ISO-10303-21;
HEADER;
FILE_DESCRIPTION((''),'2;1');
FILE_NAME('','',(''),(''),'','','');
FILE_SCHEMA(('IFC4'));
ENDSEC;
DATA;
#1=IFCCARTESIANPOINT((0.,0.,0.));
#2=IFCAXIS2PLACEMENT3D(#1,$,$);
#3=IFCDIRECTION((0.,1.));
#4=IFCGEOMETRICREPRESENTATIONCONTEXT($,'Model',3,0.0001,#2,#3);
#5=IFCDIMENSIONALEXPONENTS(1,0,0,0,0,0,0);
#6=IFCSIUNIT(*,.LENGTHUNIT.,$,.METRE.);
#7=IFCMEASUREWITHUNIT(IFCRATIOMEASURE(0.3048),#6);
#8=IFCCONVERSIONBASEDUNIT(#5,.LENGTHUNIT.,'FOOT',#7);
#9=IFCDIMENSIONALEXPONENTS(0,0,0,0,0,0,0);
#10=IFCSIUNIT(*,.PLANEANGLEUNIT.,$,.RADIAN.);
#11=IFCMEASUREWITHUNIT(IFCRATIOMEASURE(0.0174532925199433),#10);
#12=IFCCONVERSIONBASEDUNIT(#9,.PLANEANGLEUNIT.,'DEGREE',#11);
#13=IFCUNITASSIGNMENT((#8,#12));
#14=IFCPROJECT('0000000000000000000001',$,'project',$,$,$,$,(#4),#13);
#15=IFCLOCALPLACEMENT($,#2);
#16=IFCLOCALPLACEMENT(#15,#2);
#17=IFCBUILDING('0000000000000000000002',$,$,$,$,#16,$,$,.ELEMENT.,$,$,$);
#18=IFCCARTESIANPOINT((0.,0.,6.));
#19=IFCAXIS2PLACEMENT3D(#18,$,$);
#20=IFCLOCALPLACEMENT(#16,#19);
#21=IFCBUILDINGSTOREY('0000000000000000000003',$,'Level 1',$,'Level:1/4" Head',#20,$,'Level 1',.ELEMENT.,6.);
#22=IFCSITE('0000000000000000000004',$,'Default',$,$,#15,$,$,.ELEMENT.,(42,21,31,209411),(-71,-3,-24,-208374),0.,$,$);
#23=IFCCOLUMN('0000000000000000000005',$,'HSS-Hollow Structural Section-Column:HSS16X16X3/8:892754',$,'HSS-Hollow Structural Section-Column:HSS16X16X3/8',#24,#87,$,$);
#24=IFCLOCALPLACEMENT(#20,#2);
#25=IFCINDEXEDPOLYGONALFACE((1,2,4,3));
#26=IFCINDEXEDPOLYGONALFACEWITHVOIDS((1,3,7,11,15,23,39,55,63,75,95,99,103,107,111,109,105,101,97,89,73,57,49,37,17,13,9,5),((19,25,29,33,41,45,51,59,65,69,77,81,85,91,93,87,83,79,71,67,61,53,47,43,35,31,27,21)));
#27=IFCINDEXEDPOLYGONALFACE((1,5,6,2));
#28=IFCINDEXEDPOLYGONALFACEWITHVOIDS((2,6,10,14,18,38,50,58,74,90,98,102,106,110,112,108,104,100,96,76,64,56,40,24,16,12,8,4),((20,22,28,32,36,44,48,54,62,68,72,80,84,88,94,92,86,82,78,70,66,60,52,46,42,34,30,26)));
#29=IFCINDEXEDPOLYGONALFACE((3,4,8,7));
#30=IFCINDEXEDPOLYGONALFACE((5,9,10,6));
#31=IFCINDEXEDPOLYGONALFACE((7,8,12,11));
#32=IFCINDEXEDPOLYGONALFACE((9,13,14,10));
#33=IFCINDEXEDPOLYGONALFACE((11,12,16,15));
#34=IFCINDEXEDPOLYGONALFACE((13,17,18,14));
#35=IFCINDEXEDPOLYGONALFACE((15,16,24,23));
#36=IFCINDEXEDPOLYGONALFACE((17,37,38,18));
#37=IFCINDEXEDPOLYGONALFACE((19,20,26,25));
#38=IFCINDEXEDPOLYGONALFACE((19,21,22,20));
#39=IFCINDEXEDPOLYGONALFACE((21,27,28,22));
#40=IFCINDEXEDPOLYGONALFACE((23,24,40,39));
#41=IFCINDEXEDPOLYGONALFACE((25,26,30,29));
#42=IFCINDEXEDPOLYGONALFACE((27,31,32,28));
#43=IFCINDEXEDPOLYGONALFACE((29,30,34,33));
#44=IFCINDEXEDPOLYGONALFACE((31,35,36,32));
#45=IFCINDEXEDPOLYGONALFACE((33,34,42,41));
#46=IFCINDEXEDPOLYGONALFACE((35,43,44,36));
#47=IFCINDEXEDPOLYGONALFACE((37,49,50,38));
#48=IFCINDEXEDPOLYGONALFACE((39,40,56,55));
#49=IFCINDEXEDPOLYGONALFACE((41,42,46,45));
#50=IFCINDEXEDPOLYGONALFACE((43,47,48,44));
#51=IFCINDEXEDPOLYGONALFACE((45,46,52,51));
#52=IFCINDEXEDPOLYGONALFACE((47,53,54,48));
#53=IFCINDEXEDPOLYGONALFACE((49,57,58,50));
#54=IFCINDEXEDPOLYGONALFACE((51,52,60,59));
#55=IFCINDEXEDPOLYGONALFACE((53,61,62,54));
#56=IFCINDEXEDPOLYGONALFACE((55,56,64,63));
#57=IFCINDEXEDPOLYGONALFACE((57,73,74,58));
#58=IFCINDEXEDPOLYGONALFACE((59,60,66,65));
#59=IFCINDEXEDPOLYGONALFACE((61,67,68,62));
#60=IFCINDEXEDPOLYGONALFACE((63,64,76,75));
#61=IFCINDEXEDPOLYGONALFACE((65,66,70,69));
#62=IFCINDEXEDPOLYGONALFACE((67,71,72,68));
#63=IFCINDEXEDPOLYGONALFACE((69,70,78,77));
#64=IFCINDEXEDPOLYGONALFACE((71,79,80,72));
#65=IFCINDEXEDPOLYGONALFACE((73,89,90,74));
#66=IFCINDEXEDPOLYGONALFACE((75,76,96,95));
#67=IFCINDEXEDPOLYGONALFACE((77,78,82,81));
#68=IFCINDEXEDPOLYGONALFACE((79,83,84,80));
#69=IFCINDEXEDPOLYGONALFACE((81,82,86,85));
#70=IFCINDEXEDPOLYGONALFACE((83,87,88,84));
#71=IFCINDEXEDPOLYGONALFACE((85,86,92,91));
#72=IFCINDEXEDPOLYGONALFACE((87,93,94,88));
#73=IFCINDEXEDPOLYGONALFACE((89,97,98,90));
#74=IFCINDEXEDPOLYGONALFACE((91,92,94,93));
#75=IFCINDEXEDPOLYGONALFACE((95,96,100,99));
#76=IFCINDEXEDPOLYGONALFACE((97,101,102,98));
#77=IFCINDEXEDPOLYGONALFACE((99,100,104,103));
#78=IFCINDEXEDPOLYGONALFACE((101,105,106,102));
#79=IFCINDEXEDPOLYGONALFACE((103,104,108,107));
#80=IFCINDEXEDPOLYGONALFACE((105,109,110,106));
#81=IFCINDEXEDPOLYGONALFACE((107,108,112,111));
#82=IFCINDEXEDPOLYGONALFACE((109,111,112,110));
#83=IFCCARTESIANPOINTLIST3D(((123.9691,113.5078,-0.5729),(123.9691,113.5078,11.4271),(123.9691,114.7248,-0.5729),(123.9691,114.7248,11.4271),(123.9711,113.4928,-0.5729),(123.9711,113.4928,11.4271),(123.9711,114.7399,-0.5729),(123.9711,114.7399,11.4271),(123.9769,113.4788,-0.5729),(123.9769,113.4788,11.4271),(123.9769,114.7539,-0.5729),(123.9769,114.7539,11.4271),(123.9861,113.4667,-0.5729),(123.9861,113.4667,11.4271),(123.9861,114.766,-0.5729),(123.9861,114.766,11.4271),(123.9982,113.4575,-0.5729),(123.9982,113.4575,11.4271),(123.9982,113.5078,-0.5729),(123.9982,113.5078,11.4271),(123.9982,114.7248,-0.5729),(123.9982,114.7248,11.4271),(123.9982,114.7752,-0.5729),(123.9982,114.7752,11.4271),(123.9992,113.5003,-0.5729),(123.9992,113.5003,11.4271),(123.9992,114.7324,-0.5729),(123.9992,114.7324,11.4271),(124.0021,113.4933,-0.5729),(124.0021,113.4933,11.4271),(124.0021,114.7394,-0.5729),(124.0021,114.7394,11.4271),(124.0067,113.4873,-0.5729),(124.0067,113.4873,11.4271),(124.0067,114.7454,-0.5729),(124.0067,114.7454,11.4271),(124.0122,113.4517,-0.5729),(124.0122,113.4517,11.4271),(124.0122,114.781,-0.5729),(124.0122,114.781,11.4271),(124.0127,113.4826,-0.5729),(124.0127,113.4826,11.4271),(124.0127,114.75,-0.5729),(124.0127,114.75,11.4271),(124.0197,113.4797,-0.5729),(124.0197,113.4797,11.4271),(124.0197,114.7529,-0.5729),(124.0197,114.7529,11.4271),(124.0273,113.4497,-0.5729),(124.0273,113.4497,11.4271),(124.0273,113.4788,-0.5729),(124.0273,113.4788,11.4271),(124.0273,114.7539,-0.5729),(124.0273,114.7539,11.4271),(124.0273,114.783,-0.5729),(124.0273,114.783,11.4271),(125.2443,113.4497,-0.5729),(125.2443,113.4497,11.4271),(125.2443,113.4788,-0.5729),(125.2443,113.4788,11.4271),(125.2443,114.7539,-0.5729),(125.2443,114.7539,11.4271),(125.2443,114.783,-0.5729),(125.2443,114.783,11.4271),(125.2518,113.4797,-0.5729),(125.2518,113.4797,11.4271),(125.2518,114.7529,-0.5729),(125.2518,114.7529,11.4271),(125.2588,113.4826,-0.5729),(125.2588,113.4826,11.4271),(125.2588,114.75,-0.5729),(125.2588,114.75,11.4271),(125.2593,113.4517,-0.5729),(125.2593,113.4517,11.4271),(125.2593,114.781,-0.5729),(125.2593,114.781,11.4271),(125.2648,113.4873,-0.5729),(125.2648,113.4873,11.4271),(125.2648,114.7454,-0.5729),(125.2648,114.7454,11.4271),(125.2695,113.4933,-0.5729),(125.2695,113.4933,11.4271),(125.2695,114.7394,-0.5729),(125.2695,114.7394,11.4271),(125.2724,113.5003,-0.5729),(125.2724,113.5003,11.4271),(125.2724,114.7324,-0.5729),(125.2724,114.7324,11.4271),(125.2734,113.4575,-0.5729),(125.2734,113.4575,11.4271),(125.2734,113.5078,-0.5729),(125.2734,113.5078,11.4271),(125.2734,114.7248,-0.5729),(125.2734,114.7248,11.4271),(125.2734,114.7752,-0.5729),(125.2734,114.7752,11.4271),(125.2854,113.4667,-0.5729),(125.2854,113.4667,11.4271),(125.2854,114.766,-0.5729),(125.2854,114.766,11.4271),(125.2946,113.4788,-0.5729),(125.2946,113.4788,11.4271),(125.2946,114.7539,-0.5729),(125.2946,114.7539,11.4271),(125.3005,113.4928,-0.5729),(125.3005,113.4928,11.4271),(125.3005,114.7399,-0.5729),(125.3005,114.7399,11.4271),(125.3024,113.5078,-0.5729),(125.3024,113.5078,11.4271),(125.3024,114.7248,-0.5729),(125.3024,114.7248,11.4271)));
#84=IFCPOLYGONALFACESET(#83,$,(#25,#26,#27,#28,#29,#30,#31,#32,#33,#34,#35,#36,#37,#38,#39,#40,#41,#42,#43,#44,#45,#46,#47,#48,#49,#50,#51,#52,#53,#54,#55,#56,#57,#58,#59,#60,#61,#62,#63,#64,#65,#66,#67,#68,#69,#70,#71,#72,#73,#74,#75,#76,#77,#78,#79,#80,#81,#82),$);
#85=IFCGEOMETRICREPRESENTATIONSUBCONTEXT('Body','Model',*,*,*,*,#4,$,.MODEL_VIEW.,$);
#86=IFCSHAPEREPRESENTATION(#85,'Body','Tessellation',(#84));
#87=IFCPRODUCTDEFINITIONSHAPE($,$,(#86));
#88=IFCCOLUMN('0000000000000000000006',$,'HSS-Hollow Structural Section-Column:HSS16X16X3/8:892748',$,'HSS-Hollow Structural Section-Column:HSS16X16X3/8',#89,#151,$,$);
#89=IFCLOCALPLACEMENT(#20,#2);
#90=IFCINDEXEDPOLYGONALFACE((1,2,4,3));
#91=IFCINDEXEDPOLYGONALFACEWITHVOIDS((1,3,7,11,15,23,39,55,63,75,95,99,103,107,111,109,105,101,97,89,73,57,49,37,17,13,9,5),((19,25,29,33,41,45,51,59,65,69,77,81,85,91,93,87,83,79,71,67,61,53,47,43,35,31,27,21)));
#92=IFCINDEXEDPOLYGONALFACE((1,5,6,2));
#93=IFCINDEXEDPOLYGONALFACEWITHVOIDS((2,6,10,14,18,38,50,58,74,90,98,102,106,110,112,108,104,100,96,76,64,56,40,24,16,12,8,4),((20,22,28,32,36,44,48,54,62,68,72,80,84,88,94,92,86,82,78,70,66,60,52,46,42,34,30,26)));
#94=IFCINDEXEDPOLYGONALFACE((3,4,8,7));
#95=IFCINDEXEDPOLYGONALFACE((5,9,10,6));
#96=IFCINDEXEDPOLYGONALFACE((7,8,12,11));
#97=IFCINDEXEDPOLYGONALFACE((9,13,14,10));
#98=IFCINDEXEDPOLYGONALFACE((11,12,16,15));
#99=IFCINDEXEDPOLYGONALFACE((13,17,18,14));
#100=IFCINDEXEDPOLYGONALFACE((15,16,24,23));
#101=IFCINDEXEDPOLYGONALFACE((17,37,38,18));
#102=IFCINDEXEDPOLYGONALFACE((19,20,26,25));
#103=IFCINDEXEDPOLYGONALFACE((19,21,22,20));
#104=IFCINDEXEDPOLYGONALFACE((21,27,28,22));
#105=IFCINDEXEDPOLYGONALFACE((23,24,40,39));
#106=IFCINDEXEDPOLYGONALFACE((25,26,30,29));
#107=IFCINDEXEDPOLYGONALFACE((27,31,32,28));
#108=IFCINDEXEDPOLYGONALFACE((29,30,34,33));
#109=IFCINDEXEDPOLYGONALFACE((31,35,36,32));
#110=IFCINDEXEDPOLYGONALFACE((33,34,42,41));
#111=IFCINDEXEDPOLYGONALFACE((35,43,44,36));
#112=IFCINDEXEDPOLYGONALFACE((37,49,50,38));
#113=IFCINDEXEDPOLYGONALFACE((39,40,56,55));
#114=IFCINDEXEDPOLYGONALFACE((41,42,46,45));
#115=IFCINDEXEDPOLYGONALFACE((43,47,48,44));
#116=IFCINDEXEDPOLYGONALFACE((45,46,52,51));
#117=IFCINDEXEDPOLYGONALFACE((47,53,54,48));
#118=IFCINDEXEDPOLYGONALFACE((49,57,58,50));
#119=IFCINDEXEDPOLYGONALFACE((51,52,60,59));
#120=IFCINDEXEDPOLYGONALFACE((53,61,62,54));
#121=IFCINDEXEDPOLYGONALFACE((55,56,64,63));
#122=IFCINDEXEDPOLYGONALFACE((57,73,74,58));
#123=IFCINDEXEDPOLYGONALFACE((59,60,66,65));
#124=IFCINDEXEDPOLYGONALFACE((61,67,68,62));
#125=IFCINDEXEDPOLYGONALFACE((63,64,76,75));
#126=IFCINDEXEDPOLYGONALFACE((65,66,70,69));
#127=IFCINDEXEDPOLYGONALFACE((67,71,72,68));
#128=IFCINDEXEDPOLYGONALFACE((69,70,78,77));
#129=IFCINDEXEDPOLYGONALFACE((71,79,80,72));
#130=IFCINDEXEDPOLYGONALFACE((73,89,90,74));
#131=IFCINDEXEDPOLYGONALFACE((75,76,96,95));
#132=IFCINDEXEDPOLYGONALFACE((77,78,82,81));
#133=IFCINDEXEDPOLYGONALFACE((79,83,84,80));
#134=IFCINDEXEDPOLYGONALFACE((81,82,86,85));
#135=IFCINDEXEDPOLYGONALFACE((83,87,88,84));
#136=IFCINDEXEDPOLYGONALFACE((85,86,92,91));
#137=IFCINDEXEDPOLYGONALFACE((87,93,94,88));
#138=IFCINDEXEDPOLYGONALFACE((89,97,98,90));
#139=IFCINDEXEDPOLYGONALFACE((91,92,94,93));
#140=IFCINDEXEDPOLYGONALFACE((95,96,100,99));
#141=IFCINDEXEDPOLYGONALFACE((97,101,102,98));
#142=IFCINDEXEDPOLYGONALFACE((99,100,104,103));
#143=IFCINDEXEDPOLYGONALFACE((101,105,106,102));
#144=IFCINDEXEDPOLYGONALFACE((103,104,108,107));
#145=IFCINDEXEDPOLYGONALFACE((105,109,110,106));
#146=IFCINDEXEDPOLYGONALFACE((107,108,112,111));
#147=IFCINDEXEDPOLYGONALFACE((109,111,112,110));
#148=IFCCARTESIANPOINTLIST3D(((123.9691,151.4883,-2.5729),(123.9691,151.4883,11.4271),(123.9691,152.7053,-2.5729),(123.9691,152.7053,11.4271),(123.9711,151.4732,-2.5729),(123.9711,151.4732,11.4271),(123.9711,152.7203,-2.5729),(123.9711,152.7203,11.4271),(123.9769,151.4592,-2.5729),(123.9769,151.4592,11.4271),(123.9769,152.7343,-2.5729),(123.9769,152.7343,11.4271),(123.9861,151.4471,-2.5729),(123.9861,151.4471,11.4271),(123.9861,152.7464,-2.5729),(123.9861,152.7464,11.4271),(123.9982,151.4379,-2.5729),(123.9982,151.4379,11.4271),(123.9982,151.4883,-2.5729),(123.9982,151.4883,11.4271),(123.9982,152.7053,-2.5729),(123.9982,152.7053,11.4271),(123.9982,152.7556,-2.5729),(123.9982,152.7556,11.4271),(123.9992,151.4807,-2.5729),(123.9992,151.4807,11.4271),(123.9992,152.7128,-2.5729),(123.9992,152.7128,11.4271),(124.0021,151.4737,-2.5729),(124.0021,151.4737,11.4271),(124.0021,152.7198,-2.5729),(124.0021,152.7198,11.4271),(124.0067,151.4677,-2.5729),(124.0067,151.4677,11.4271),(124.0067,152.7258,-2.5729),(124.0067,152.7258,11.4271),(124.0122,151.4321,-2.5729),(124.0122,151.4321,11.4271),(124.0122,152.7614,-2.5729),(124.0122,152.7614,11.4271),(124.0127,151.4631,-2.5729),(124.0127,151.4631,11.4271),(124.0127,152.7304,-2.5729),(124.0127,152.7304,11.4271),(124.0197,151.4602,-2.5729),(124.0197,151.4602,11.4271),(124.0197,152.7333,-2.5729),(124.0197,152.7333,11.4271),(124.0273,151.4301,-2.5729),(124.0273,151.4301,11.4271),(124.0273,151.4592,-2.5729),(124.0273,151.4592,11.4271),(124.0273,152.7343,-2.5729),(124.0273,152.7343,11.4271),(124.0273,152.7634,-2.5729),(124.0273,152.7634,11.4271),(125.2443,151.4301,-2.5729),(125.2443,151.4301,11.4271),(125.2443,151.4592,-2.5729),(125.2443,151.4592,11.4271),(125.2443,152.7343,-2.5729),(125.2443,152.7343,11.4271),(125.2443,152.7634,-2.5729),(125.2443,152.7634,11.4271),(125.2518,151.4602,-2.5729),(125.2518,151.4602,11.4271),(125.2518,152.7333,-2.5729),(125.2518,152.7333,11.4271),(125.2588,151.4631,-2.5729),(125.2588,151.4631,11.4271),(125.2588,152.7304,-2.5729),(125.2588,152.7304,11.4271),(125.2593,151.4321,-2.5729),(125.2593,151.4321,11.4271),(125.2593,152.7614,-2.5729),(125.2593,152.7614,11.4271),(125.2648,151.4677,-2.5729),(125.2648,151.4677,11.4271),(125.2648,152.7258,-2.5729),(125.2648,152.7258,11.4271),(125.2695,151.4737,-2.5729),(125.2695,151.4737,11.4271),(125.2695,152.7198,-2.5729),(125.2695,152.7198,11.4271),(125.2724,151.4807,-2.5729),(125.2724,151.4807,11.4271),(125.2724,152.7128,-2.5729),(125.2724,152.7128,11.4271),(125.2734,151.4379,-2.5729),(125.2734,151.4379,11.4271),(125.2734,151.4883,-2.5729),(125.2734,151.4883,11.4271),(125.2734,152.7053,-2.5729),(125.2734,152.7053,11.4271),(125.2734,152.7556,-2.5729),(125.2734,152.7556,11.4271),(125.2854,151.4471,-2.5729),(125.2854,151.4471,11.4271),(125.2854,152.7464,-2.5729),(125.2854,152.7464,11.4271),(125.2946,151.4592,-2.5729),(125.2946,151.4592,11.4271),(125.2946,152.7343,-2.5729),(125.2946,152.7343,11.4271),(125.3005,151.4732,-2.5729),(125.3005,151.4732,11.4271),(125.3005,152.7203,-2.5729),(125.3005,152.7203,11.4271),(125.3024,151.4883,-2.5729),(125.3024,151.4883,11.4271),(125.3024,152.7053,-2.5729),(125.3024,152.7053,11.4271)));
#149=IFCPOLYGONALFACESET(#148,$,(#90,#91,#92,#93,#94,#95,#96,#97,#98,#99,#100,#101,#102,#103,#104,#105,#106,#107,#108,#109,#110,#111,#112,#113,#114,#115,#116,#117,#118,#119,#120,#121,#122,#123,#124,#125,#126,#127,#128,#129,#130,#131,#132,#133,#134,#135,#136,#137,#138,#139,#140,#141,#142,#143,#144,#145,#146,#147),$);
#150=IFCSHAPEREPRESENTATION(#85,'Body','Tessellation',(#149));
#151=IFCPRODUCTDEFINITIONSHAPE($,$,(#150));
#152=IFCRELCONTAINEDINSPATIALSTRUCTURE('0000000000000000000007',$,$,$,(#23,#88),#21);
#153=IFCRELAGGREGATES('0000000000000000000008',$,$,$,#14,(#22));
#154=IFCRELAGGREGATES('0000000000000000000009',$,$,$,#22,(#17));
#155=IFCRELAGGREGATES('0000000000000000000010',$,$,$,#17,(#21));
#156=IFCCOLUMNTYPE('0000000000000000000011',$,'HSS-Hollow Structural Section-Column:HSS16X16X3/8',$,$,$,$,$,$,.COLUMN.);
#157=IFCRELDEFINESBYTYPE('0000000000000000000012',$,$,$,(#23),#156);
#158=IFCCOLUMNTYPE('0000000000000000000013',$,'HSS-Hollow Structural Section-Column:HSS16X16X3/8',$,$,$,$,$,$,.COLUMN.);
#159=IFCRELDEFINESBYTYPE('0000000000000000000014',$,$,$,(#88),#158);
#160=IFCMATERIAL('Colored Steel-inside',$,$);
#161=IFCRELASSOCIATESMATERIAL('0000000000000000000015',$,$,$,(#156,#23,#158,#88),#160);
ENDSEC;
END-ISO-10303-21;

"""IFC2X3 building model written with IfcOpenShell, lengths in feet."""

from ifc_helpers import new_model, entity, si_unit, converted_unit, direction, frame, frame_2d, origin, place, context, subcontext, project, spatial, polyline, circle_curve, parameter, trimmed, segment, composite_curve, outline, extrude, source, transform, mapped, material, type_object, type_shapes, element, save


model = new_model("IFC2X3")

# Units and contexts
model_context = context("Model", 3, precision=0.0001, world=origin(), true_north=direction((0.0, 1.0)))
body_context = subcontext(model_context, "Body", "Model", "MODEL_VIEW")
ifc_project = project(units=[converted_unit("LENGTHUNIT", "FOOT", entity("IfcRatioMeasure", 0.3048), si_unit("LENGTHUNIT", "METRE"), dimensions=[1, 0, 0, 0, 0, 0, 0]), converted_unit("PLANEANGLEUNIT", "DEGREE", entity("IfcRatioMeasure", 0.0174532925199433), si_unit("PLANEANGLEUNIT", "RADIAN"), dimensions=[0, 0, 0, 0, 0, 0, 0])], contexts=[model_context])

# Site, building, storey
site_placement = place(None, origin())
site = spatial("IfcSite", under=ifc_project, at=site_placement, Name="Default", CompositionType="ELEMENT", RefLatitude=(42, 21, 31, 209411), RefLongitude=(-71, -3, -24, -208374), RefElevation=0.0)
building_placement = place(site_placement, origin())
building = spatial("IfcBuilding", under=site, at=building_placement, CompositionType="ELEMENT")
storey_placement = place(building_placement, frame((0.0, 0.0, 6.0)))
storey = spatial("IfcBuildingStorey", under=building, at=storey_placement, Name="Level 1", ObjectType="Level:1/4\" Head", LongName="Level 1", CompositionType="ELEMENT", Elevation=6.0)

# Columns
ifc_material_1 = material(Name="Colored Steel-inside")
column_type_1 = type_object("IfcColumnType", Name="HSS-Hollow Structural Section-Column:HSS16X16X3/8", PredefinedType="COLUMN", material=ifc_material_1)
shared_shape_1 = source(origin(), body_context, "Body", "SweptSolid", [
    extrude(outline(composite_curve([segment(polyline([(-0.6085, -0.6667), (0.6085, -0.6667)]), True, "CONTINUOUS"), segment(trimmed(circle_curve(frame_2d((0.6085, -0.6085), x_axis=(-1.0, 0.0)), 0.0582), [parameter(90.0)], [parameter(180.0)], True, "PARAMETER"), True, "CONTINUOUS"), segment(polyline([(0.6667, -0.6085), (0.6667, 0.6085)]), True, "CONTINUOUS"), segment(trimmed(circle_curve(frame_2d((0.6085, 0.6085), x_axis=(-1.0, 0.0)), 0.0582), [parameter(180.0)], [parameter(270.0)], True, "PARAMETER"), True, "CONTINUOUS"), segment(polyline([(0.6085, 0.6667), (-0.6085, 0.6667)]), True, "CONTINUOUS"), segment(trimmed(circle_curve(frame_2d((-0.6085, 0.6085), x_axis=(-1.0, 0.0)), 0.0582), [parameter(270.0)], [parameter(360.0)], True, "PARAMETER"), True, "CONTINUOUS"), segment(polyline([(-0.6667, 0.6085), (-0.6667, -0.6085)]), True, "CONTINUOUS"), segment(trimmed(circle_curve(frame_2d((-0.6085, -0.6085), x_axis=(-1.0, 0.0)), 0.0582), [parameter(360.0)], [parameter(90.0)], True, "PARAMETER"), True, "CONTINUOUS")], self_intersect=False), holes=[composite_curve([segment(trimmed(circle_curve(frame_2d((-0.6085, -0.6085), x_axis=(-1.0, 0.0)), 0.0291), [parameter(0.0)], [parameter(90.0)], True, "PARAMETER"), False, "CONTINUOUS"), segment(polyline([(-0.6376, -0.6085), (-0.6376, 0.6085)]), True, "CONTINUOUS"), segment(trimmed(circle_curve(frame_2d((-0.6085, 0.6085), x_axis=(-1.0, 0.0)), 0.0291), [parameter(270.0)], [parameter(360.0)], True, "PARAMETER"), False, "CONTINUOUS"), segment(polyline([(-0.6085, 0.6376), (0.6085, 0.6376)]), True, "CONTINUOUS"), segment(trimmed(circle_curve(frame_2d((0.6085, 0.6085), x_axis=(-1.0, 0.0)), 0.0291), [parameter(180.0)], [parameter(270.0)], True, "PARAMETER"), False, "CONTINUOUS"), segment(polyline([(0.6376, 0.6085), (0.6376, -0.6085)]), True, "CONTINUOUS"), segment(trimmed(circle_curve(frame_2d((0.6085, -0.6085), x_axis=(-1.0, 0.0)), 0.0291), [parameter(90.0)], [parameter(180.0)], True, "PARAMETER"), False, "CONTINUOUS"), segment(polyline([(0.6085, -0.6376), (-0.6085, -0.6376)]), True, "CONTINUOUS")], self_intersect=False)]), frame((0.0, 0.0, 5.4271), z_axis=(0.0, 0.0, 1.0), x_axis=(-1.0, 0.0, 0.0)), (0.0, 0.0, 1.0), 12.0),
])
type_shapes(column_type_1, [shared_shape_1])
for number, where, name in (
    (1, (124.6358, 114.1163, -6.0), "HSS-Hollow Structural Section-Column:HSS16X16X3/8:892754"),
):
    element("IfcColumn", number, at=place(storey_placement, frame(where)), inside=storey, type_object=column_type_1, material=ifc_material_1, Name=name, ObjectType="HSS-Hollow Structural Section-Column:HSS16X16X3/8", context=body_context, shape_type="MappedRepresentation", body=[
        mapped(shared_shape_1, transform((0.0, 0.0, 0.0), scale=1.0)),
    ])
column_type_2 = type_object("IfcColumnType", Name="HSS-Hollow Structural Section-Column:HSS16X16X3/8", PredefinedType="COLUMN", material=ifc_material_1)
shared_shape_2 = source(origin(), body_context, "Body", "SweptSolid", [
    extrude(outline(composite_curve([segment(polyline([(-0.6085, -0.6667), (0.6085, -0.6667)]), True, "CONTINUOUS"), segment(trimmed(circle_curve(frame_2d((0.6085, -0.6085), x_axis=(-1.0, 0.0)), 0.0582), [parameter(90.0)], [parameter(180.0)], True, "PARAMETER"), True, "CONTINUOUS"), segment(polyline([(0.6667, -0.6085), (0.6667, 0.6085)]), True, "CONTINUOUS"), segment(trimmed(circle_curve(frame_2d((0.6085, 0.6085), x_axis=(-1.0, 0.0)), 0.0582), [parameter(180.0)], [parameter(270.0)], True, "PARAMETER"), True, "CONTINUOUS"), segment(polyline([(0.6085, 0.6667), (-0.6085, 0.6667)]), True, "CONTINUOUS"), segment(trimmed(circle_curve(frame_2d((-0.6085, 0.6085), x_axis=(-1.0, 0.0)), 0.0582), [parameter(270.0)], [parameter(360.0)], True, "PARAMETER"), True, "CONTINUOUS"), segment(polyline([(-0.6667, 0.6085), (-0.6667, -0.6085)]), True, "CONTINUOUS"), segment(trimmed(circle_curve(frame_2d((-0.6085, -0.6085), x_axis=(-1.0, 0.0)), 0.0582), [parameter(360.0)], [parameter(90.0)], True, "PARAMETER"), True, "CONTINUOUS")], self_intersect=False), holes=[composite_curve([segment(trimmed(circle_curve(frame_2d((-0.6085, -0.6085), x_axis=(-1.0, 0.0)), 0.0291), [parameter(0.0)], [parameter(90.0)], True, "PARAMETER"), False, "CONTINUOUS"), segment(polyline([(-0.6376, -0.6085), (-0.6376, 0.6085)]), True, "CONTINUOUS"), segment(trimmed(circle_curve(frame_2d((-0.6085, 0.6085), x_axis=(-1.0, 0.0)), 0.0291), [parameter(270.0)], [parameter(360.0)], True, "PARAMETER"), False, "CONTINUOUS"), segment(polyline([(-0.6085, 0.6376), (0.6085, 0.6376)]), True, "CONTINUOUS"), segment(trimmed(circle_curve(frame_2d((0.6085, 0.6085), x_axis=(-1.0, 0.0)), 0.0291), [parameter(180.0)], [parameter(270.0)], True, "PARAMETER"), False, "CONTINUOUS"), segment(polyline([(0.6376, 0.6085), (0.6376, -0.6085)]), True, "CONTINUOUS"), segment(trimmed(circle_curve(frame_2d((0.6085, -0.6085), x_axis=(-1.0, 0.0)), 0.0291), [parameter(90.0)], [parameter(180.0)], True, "PARAMETER"), False, "CONTINUOUS"), segment(polyline([(0.6085, -0.6376), (-0.6085, -0.6376)]), True, "CONTINUOUS")], self_intersect=False)]), frame((0.0, 0.0, 3.4271), z_axis=(0.0, 0.0, 1.0), x_axis=(-1.0, 0.0, 0.0)), (0.0, 0.0, 1.0), 14.0),
])
type_shapes(column_type_2, [shared_shape_2])
column_placement = place(storey_placement, frame((124.6358, 152.0968, -6.0)))
element("IfcColumn", 2, at=column_placement, inside=storey, type_object=column_type_2, material=ifc_material_1, Name="HSS-Hollow Structural Section-Column:HSS16X16X3/8:892748", ObjectType="HSS-Hollow Structural Section-Column:HSS16X16X3/8", context=body_context, shape_type="MappedRepresentation", body=[
    mapped(shared_shape_2, transform((0.0, 0.0, 0.0), scale=1.0)),
])

save(model, "model.ifc")
